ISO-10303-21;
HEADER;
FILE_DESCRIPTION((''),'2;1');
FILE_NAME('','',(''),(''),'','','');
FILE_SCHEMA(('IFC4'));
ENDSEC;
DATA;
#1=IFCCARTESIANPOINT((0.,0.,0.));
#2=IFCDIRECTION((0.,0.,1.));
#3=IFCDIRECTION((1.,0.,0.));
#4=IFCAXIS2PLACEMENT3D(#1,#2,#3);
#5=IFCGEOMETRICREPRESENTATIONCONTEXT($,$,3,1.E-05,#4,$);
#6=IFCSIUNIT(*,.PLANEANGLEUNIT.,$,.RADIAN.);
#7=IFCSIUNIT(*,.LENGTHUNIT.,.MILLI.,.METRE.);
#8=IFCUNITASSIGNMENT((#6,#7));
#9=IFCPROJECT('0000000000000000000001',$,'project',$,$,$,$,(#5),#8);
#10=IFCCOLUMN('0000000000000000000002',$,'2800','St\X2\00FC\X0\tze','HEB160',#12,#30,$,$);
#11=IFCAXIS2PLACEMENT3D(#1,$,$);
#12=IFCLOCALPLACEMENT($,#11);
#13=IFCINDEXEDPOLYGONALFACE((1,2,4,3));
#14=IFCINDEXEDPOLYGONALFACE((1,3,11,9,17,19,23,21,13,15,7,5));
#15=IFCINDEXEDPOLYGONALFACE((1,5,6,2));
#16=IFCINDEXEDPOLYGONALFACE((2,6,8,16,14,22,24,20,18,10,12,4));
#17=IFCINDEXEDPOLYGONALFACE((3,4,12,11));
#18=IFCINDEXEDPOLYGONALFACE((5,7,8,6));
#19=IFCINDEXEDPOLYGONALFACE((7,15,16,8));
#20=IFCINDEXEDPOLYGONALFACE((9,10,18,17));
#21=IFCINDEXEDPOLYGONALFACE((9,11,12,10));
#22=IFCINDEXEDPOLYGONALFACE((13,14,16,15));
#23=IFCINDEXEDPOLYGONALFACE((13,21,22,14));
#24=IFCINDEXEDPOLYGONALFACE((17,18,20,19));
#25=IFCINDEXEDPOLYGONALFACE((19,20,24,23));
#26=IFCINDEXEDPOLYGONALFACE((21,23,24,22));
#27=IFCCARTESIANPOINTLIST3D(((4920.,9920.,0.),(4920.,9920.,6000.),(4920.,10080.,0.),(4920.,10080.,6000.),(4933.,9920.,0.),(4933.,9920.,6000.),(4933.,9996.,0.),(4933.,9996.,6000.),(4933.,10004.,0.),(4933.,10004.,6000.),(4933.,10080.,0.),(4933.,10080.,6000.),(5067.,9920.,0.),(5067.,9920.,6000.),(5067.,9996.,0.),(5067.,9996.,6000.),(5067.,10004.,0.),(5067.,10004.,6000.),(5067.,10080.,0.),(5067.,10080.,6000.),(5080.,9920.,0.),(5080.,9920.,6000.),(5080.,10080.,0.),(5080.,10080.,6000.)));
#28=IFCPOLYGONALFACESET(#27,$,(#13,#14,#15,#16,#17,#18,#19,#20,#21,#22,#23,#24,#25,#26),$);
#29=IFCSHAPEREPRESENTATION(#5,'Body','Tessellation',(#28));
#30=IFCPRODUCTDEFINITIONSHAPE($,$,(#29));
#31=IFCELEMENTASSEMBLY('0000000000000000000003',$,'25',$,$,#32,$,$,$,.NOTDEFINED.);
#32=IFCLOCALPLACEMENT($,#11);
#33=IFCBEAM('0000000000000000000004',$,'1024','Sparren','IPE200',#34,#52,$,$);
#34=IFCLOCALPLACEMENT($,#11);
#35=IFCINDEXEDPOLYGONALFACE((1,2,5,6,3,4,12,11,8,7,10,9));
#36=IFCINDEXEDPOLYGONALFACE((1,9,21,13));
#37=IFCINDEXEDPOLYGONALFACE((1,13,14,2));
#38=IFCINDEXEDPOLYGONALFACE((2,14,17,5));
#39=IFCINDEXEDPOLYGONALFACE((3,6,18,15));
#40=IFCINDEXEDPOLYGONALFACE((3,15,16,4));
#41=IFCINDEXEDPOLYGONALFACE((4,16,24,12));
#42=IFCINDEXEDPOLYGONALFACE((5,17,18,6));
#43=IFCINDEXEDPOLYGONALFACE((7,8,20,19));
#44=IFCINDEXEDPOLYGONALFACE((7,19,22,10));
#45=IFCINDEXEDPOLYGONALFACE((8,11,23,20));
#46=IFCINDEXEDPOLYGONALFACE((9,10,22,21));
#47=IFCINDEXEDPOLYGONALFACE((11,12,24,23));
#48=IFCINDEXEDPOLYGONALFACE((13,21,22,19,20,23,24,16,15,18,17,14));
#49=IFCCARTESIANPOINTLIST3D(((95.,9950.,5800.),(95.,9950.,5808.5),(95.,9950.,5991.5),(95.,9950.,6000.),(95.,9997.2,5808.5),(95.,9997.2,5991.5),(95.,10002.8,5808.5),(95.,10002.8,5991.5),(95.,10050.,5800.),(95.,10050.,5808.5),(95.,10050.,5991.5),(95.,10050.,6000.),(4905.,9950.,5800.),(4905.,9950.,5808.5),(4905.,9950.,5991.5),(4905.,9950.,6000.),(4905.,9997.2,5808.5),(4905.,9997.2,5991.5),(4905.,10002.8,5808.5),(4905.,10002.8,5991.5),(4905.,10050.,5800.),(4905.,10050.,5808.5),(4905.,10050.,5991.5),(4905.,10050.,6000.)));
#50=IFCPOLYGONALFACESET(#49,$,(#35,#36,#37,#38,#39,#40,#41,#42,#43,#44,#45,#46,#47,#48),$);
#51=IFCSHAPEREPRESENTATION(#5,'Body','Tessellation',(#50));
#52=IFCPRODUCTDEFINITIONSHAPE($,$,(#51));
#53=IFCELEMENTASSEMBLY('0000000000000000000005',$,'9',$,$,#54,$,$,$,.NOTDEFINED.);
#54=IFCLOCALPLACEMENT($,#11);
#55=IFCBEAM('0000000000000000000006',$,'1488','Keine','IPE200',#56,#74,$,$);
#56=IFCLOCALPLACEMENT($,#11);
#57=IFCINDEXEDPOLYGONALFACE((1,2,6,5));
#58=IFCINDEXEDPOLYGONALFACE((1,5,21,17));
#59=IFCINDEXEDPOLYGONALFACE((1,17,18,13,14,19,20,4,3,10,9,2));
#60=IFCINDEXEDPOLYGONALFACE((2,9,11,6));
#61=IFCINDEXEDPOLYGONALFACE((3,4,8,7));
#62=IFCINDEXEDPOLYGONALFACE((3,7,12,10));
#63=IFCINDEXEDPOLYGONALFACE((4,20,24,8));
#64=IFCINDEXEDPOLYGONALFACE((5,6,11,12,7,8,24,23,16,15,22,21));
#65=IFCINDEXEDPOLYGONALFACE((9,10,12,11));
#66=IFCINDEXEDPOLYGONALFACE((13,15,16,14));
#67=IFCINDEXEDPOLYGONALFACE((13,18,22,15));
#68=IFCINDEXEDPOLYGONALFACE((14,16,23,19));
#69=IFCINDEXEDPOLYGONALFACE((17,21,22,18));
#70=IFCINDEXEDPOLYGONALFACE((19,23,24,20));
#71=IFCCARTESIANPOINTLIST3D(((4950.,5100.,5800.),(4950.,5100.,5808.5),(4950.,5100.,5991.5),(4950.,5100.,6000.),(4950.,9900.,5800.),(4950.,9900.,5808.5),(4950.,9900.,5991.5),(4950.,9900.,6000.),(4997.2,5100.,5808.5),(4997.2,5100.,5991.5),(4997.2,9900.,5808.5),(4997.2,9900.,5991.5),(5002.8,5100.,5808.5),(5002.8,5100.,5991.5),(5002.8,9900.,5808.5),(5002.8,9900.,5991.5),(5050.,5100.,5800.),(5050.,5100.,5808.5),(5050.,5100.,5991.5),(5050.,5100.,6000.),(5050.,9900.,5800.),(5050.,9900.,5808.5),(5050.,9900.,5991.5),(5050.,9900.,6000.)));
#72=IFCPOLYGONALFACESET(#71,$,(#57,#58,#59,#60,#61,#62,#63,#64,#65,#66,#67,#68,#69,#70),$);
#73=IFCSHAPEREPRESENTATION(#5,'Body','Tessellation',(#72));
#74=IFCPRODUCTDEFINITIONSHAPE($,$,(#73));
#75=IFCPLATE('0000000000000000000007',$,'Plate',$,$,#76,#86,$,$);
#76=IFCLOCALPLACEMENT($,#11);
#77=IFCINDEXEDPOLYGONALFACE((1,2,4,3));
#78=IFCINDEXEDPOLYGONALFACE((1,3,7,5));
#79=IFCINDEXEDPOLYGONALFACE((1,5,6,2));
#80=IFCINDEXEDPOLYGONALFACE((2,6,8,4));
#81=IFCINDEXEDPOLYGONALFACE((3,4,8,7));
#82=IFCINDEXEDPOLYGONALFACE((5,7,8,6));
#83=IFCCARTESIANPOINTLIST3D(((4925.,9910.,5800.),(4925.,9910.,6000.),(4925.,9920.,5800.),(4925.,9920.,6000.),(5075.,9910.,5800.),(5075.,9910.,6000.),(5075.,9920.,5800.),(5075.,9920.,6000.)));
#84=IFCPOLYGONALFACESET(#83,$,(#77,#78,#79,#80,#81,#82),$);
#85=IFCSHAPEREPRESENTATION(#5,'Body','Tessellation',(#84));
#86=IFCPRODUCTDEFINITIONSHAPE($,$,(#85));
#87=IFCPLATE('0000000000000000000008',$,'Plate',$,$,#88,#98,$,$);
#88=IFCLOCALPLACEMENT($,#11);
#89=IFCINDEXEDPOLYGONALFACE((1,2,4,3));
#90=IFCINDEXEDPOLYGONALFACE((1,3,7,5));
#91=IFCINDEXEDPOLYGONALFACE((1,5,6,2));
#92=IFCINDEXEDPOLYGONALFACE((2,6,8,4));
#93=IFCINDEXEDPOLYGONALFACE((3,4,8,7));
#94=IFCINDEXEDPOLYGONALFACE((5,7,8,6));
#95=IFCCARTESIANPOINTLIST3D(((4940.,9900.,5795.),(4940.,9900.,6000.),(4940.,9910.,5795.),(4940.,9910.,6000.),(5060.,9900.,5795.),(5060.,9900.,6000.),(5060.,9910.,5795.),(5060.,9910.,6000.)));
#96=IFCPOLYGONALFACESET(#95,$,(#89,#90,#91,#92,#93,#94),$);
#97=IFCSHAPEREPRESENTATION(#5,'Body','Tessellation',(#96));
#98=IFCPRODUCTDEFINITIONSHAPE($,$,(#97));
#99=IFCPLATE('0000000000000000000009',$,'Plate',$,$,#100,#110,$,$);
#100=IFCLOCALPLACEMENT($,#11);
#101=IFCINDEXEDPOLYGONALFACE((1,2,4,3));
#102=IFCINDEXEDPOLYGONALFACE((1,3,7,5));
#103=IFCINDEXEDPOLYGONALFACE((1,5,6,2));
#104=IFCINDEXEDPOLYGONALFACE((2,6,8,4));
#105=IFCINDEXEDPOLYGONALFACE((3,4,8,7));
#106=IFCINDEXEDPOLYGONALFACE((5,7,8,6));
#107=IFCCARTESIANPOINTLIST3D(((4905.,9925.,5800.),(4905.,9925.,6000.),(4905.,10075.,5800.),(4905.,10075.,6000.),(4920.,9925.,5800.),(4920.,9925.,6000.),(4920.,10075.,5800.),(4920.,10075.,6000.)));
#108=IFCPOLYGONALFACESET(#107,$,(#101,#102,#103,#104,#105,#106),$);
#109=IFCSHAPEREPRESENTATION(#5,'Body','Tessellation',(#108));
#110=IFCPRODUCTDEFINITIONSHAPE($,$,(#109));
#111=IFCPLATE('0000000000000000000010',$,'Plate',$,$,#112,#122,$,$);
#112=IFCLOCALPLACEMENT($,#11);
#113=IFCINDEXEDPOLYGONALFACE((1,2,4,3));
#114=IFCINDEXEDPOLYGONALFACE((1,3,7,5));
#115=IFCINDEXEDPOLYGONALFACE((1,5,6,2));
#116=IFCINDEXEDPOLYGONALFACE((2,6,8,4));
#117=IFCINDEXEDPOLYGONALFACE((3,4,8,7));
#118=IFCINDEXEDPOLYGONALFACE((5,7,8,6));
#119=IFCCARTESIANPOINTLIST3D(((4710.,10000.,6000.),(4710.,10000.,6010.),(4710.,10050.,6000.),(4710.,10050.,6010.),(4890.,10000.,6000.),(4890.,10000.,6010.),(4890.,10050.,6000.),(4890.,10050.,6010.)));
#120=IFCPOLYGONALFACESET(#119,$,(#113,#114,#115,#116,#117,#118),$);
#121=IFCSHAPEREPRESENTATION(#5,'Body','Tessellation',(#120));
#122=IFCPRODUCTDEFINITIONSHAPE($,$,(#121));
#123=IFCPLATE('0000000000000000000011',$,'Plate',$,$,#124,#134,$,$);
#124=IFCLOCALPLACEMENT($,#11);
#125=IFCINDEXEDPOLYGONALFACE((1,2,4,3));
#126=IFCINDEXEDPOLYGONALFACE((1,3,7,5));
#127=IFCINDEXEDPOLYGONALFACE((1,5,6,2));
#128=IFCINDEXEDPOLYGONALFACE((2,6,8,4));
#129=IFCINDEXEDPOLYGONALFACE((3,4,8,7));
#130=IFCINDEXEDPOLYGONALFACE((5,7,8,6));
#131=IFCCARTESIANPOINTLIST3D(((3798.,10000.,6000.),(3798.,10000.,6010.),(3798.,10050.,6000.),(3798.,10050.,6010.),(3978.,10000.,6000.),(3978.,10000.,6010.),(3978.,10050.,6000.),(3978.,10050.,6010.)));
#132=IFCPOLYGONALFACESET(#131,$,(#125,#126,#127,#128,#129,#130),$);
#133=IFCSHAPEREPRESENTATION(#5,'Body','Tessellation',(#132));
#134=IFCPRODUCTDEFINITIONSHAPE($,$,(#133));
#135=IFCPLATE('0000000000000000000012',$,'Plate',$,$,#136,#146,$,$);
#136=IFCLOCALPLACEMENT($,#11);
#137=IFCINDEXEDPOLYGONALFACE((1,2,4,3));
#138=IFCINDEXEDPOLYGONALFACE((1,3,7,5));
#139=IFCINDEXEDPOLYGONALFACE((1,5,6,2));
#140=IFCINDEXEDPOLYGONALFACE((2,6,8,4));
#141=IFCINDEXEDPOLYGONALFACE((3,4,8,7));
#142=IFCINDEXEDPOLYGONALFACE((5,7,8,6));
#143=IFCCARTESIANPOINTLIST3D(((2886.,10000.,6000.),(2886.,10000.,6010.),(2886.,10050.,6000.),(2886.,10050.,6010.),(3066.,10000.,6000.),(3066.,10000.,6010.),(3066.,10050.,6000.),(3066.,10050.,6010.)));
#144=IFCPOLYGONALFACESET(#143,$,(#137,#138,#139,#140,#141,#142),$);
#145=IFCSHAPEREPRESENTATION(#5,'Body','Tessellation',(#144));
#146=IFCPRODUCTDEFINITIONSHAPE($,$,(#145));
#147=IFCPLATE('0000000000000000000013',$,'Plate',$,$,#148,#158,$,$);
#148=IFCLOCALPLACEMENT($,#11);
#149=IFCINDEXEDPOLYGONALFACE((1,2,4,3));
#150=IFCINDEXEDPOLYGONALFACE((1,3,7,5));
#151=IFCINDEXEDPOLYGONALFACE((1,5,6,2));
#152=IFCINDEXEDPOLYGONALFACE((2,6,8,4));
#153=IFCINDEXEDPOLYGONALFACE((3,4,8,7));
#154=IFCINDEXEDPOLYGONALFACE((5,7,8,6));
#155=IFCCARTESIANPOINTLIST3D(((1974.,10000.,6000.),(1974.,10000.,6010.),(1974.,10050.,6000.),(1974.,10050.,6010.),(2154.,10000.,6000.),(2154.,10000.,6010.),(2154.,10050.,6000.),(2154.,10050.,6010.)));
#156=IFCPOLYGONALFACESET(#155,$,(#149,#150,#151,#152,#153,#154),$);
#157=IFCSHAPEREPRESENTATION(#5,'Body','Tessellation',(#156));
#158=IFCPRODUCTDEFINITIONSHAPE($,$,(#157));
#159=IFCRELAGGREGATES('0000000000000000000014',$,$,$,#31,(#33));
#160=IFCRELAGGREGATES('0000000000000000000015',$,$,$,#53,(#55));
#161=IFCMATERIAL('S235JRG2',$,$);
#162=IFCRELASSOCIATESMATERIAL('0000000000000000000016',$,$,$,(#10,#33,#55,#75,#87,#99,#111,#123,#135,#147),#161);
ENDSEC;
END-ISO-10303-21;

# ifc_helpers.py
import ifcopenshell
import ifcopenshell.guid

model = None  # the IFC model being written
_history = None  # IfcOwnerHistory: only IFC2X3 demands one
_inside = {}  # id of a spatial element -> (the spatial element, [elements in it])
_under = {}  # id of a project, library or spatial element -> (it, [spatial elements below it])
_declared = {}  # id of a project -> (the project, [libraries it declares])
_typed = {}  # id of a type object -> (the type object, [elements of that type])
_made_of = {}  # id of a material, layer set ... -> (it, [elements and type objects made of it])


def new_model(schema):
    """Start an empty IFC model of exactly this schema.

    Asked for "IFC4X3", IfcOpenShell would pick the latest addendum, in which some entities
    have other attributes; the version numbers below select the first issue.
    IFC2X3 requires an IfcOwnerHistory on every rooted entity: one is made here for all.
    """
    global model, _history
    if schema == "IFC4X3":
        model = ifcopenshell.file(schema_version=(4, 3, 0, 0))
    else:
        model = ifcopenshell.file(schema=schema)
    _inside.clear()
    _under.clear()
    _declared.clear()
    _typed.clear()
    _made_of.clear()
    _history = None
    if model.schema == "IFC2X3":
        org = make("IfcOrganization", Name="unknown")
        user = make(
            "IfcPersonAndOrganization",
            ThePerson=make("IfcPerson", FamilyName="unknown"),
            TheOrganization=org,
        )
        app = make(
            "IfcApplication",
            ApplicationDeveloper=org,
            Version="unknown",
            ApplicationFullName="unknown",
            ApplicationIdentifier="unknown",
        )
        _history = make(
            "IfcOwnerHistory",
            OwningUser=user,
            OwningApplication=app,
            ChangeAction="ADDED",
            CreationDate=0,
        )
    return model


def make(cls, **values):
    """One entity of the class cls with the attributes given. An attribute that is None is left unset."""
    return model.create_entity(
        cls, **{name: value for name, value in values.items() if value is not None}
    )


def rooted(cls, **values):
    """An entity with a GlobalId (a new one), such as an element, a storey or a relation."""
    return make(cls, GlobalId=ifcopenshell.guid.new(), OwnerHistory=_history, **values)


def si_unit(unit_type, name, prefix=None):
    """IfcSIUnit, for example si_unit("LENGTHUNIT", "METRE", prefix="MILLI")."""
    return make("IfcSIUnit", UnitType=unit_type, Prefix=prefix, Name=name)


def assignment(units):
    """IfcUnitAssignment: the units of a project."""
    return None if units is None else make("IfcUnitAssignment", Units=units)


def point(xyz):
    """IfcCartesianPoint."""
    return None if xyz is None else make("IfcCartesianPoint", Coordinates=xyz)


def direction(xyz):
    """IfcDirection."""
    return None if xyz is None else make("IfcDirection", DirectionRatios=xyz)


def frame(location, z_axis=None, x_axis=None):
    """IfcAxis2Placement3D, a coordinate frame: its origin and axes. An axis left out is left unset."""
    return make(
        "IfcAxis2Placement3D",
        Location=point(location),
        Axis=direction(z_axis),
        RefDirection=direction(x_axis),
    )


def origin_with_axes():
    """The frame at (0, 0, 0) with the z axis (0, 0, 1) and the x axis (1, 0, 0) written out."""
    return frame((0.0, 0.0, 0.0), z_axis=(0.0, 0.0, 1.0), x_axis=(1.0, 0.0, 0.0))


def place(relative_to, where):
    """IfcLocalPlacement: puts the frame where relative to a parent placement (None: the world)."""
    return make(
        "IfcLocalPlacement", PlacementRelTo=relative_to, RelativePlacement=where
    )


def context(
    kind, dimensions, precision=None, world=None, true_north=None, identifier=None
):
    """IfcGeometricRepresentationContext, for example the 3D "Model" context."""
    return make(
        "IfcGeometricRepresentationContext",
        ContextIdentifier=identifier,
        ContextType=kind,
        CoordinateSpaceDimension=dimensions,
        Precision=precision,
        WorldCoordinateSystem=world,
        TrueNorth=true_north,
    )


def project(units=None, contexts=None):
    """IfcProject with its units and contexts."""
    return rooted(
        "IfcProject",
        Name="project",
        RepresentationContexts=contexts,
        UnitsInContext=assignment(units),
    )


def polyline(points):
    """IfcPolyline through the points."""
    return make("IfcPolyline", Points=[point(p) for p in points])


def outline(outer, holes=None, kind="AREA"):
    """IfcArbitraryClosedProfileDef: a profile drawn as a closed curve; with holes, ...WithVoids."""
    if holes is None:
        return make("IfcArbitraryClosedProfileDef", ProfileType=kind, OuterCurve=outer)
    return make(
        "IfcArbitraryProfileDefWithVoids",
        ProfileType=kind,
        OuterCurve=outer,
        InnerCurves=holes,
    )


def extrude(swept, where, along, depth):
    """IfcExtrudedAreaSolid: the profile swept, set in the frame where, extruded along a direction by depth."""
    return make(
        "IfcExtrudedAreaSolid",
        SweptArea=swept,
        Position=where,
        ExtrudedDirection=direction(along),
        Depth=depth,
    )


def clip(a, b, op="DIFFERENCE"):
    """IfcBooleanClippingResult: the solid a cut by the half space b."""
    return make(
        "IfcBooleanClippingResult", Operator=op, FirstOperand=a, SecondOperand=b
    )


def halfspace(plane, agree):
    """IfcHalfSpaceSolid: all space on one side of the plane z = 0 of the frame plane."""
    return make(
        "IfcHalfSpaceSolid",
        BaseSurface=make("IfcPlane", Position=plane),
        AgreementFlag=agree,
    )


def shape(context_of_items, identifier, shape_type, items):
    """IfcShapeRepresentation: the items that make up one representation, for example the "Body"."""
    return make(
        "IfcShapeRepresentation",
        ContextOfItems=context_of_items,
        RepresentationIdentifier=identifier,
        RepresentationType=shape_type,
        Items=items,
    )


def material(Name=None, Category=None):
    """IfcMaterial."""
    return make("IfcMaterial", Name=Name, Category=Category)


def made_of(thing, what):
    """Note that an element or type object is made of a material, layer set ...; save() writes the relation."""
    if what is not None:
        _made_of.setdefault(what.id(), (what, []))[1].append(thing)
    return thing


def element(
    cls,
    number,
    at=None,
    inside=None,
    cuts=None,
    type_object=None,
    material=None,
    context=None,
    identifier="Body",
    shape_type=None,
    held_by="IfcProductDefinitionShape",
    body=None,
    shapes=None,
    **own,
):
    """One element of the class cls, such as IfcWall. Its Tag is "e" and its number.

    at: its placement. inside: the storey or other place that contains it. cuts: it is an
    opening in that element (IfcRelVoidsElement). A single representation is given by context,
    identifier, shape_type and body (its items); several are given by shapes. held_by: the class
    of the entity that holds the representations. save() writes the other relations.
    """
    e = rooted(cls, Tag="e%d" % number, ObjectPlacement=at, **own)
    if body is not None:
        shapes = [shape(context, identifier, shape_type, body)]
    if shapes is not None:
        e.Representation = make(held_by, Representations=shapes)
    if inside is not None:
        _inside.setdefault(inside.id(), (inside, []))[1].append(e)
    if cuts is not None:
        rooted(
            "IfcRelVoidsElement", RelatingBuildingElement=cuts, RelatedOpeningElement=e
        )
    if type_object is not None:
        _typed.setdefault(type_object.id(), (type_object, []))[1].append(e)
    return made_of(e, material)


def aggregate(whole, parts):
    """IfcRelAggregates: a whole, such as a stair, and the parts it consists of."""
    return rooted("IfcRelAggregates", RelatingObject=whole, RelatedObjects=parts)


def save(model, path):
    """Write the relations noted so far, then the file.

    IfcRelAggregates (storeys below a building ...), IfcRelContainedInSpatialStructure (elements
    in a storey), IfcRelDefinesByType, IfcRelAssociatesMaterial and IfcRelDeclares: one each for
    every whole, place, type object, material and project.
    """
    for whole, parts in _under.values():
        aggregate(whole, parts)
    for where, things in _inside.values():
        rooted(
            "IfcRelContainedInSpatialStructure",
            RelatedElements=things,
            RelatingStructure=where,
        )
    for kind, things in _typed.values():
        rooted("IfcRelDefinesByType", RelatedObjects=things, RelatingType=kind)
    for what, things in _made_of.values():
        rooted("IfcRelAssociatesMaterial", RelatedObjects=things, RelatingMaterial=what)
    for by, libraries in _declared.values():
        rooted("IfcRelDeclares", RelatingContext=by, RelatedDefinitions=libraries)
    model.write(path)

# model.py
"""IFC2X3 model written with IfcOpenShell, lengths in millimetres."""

from ifc_helpers import new_model, si_unit, frame, origin_with_axes, place, context, project, polyline, outline, extrude, clip, halfspace, material, element, aggregate, save


model = new_model("IFC2X3")

# Units and contexts
context_of_model = context(None, 3, precision=1e-05, world=origin_with_axes())
ifc_project = project(units=[si_unit("PLANEANGLEUNIT", "RADIAN"), si_unit("LENGTHUNIT", "METRE", prefix="MILLI")], contexts=[context_of_model])

# Column
ifc_material = material(Name="S235JRG2")
placement_1 = place(None, frame((5000.0, 10000.0, 6000.0), z_axis=(1.0, 0.0, 0.0), x_axis=(0.0, 0.0, -1.0)))
column_placement = place(placement_1, origin_with_axes())
element("IfcColumn", 1, at=column_placement, material=ifc_material, Name="2800", Description="Stütze", ObjectType="HEB160", context=context_of_model, shape_type="Clipping", body=[
    clip(extrude(outline(polyline([(80.0, -80.0), (80.0, -67.0), (4.0, -67.0), (4.0, 67.0), (80.0, 67.0), (80.0, 80.0), (-80.0, 80.0), (-80.0, 67.0), (-4.0, 67.0), (-4.0, -67.0), (-80.0, -67.0), (-80.0, -80.0), (80.0, -80.0), (80.0, -80.0)])), frame((0.0, 0.0, 0.0), z_axis=(1.0, 0.0, 0.0), x_axis=(0.0, 1.0, 0.0)), (0.0, 0.0, 1.0), 6000.0), halfspace(frame((6000.0, 0.0, 0.0), z_axis=(1.0, 0.0, 0.0), x_axis=(0.0, 0.0, 1.0)), False)),
])

# Element assemblies, beams
assembly_1_placement = place(None, frame((5000.0, 10000.0, 6000.0), z_axis=(0.0, 0.0, 1.0), x_axis=(-1.0, 0.0, 0.0)))
assembly_1 = element("IfcElementAssembly", 2, at=assembly_1_placement, Name="25", PredefinedType="NOTDEFINED")
placement_2 = place(None, frame((5000.0, 10000.0, 5900.0), z_axis=(0.0, 0.0, 1.0), x_axis=(-1.0, 0.0, 0.0)))
beam_1_placement = place(placement_2, origin_with_axes())
beam_1 = element("IfcBeam", 3, at=beam_1_placement, material=ifc_material, Name="1024", Description="Sparren", ObjectType="IPE200", context=context_of_model, shape_type="Clipping", body=[
    clip(clip(extrude(outline(polyline([(50.0, -100.0), (50.0, -91.5), (2.8, -91.5), (2.8, 91.5), (50.0, 91.5), (50.0, 100.0), (-50.0, 100.0), (-50.0, 91.5), (-2.8, 91.5), (-2.8, -91.5), (-50.0, -91.5), (-50.0, -100.0), (50.0, -100.0), (50.0, -100.0)])), frame((0.0, 0.0, 0.0), z_axis=(1.0, 0.0, 0.0), x_axis=(0.0, 1.0, 0.0)), (0.0, 0.0, 1.0), 5000.0), halfspace(frame((4905.0, 0.0, 100.0), z_axis=(1.0, 0.0, 0.0), x_axis=(0.0, 0.0, 1.0)), False)), halfspace(frame((95.0, 0.0, 100.0), z_axis=(-1.0, 0.0, 0.0), x_axis=(0.0, 0.0, -1.0)), False)),
])
aggregate(assembly_1, [beam_1])
assembly_2_placement = place(None, frame((5000.0, 10000.0, 6000.0), z_axis=(0.0, 0.0, 1.0), x_axis=(0.0, -1.0, 0.0)))
assembly_2 = element("IfcElementAssembly", 4, at=assembly_2_placement, Name="9", PredefinedType="NOTDEFINED")
placement_3 = place(None, frame((5000.0, 10000.0, 5900.0), z_axis=(0.0, 0.0, 1.0), x_axis=(0.0, -1.0, 0.0)))
beam_2_placement = place(placement_3, origin_with_axes())
beam_2 = element("IfcBeam", 5, at=beam_2_placement, material=ifc_material, Name="1488", Description="Keine", ObjectType="IPE200", context=context_of_model, shape_type="Clipping", body=[
    clip(clip(extrude(outline(polyline([(50.0, -100.0), (50.0, -91.5), (2.8, -91.5), (2.8, 91.5), (50.0, 91.5), (50.0, 100.0), (-50.0, 100.0), (-50.0, 91.5), (-2.8, 91.5), (-2.8, -91.5), (-50.0, -91.5), (-50.0, -100.0), (50.0, -100.0), (50.0, -100.0)])), frame((0.0, 0.0, 0.0), z_axis=(1.0, 0.0, 0.0), x_axis=(0.0, 1.0, 0.0)), (0.0, 0.0, 1.0), 5000.0), halfspace(frame((100.0, 0.0, 100.0), z_axis=(-1.0, 0.0, 0.0), x_axis=(0.0, 0.0, -1.0)), False)), halfspace(frame((4900.0, 0.0, 100.0), z_axis=(1.0, 0.0, 0.0), x_axis=(0.0, 0.0, 1.0)), False)),
])
aggregate(assembly_2, [beam_2])

# Plates
placement_4 = place(None, origin_with_axes())
plate_1_placement = place(placement_4, frame((5075.0, 9920.0, 6000.0), z_axis=(0.0, 0.0, -1.0), x_axis=(0.0, -1.0, 0.0)))
element("IfcPlate", 6, at=plate_1_placement, material=ifc_material, Name="Plate", context=context_of_model, shape_type="SweptSolid", body=[
    extrude(outline(polyline([(0.0, 0.0), (150.0, 0.0), (150.0, 200.0), (0.0, 200.0), (0.0, 0.0)])), frame((0.0, 0.0, 0.0), z_axis=(1.0, 0.0, 0.0), x_axis=(0.0, 1.0, 0.0)), (0.0, 0.0, 1.0), 10.0),
])
placement_5 = place(None, origin_with_axes())
plate_2_placement = place(placement_5, frame((5060.0, 9900.0, 5795.0), z_axis=(0.0, 0.0, 1.0), x_axis=(0.0, 1.0, 0.0)))
element("IfcPlate", 7, at=plate_2_placement, material=ifc_material, Name="Plate", context=context_of_model, shape_type="SweptSolid", body=[
    extrude(outline(polyline([(0.0, 0.0), (120.0, 0.0), (120.0, 205.0), (0.0, 205.0), (0.0, 0.0)])), frame((0.0, 0.0, 0.0), z_axis=(1.0, 0.0, 0.0), x_axis=(0.0, 1.0, 0.0)), (0.0, 0.0, 1.0), 10.0),
])
placement_6 = place(None, origin_with_axes())
plate_3_placement = place(placement_6, frame((4905.0, 10075.0, 5800.0), z_axis=(0.0, -1.0, 0.0), x_axis=(1.0, 0.0, 0.0)))
element("IfcPlate", 8, at=plate_3_placement, material=ifc_material, Name="Plate", context=context_of_model, shape_type="SweptSolid", body=[
    extrude(outline(polyline([(0.0, 0.0), (200.0, 0.0), (200.0, 150.0), (0.0, 150.0), (0.0, 0.0)])), frame((0.0, 0.0, 0.0), z_axis=(1.0, 0.0, 0.0), x_axis=(0.0, 1.0, 0.0)), (0.0, 0.0, 1.0), 15.0),
])
placement_7 = place(None, origin_with_axes())
plate_4_placement = place(placement_7, frame((4890.0, 10000.0, 6010.0), z_axis=(0.0, 1.0, 0.0), x_axis=(0.0, 0.0, -1.0)))
element("IfcPlate", 9, at=plate_4_placement, material=ifc_material, Name="Plate", context=context_of_model, shape_type="SweptSolid", body=[
    extrude(outline(polyline([(0.0, 0.0), (180.0, 0.0), (180.0, 50.0), (0.0, 50.0), (0.0, 0.0)])), frame((0.0, 0.0, 0.0), z_axis=(1.0, 0.0, 0.0), x_axis=(0.0, 1.0, 0.0)), (0.0, 0.0, 1.0), 10.0),
])
placement_8 = place(None, origin_with_axes())
plate_5_placement = place(placement_8, frame((3978.0, 10000.0, 6010.0), z_axis=(0.0, 1.0, 0.0), x_axis=(0.0, 0.0, -1.0)))
element("IfcPlate", 10, at=plate_5_placement, material=ifc_material, Name="Plate", context=context_of_model, shape_type="SweptSolid", body=[
    extrude(outline(polyline([(0.0, 0.0), (180.0, 0.0), (180.0, 50.0), (0.0, 50.0), (0.0, 0.0)])), frame((0.0, 0.0, 0.0), z_axis=(1.0, 0.0, 0.0), x_axis=(0.0, 1.0, 0.0)), (0.0, 0.0, 1.0), 10.0),
])
placement_9 = place(None, origin_with_axes())
plate_6_placement = place(placement_9, frame((3066.0, 10000.0, 6010.0), z_axis=(0.0, 1.0, 0.0), x_axis=(0.0, 0.0, -1.0)))
element("IfcPlate", 11, at=plate_6_placement, material=ifc_material, Name="Plate", context=context_of_model, shape_type="SweptSolid", body=[
    extrude(outline(polyline([(0.0, 0.0), (180.0, 0.0), (180.0, 50.0), (0.0, 50.0), (0.0, 0.0)])), frame((0.0, 0.0, 0.0), z_axis=(1.0, 0.0, 0.0), x_axis=(0.0, 1.0, 0.0)), (0.0, 0.0, 1.0), 10.0),
])
placement_10 = place(None, origin_with_axes())
plate_7_placement = place(placement_10, frame((2154.0, 10000.0, 6010.0), z_axis=(0.0, 1.0, 0.0), x_axis=(0.0, 0.0, -1.0)))
element("IfcPlate", 12, at=plate_7_placement, material=ifc_material, Name="Plate", context=context_of_model, shape_type="SweptSolid", body=[
    extrude(outline(polyline([(0.0, 0.0), (180.0, 0.0), (180.0, 50.0), (0.0, 50.0), (0.0, 0.0)])), frame((0.0, 0.0, 0.0), z_axis=(1.0, 0.0, 0.0), x_axis=(0.0, 1.0, 0.0)), (0.0, 0.0, 1.0), 10.0),
])

save(model, "model.ifc")
